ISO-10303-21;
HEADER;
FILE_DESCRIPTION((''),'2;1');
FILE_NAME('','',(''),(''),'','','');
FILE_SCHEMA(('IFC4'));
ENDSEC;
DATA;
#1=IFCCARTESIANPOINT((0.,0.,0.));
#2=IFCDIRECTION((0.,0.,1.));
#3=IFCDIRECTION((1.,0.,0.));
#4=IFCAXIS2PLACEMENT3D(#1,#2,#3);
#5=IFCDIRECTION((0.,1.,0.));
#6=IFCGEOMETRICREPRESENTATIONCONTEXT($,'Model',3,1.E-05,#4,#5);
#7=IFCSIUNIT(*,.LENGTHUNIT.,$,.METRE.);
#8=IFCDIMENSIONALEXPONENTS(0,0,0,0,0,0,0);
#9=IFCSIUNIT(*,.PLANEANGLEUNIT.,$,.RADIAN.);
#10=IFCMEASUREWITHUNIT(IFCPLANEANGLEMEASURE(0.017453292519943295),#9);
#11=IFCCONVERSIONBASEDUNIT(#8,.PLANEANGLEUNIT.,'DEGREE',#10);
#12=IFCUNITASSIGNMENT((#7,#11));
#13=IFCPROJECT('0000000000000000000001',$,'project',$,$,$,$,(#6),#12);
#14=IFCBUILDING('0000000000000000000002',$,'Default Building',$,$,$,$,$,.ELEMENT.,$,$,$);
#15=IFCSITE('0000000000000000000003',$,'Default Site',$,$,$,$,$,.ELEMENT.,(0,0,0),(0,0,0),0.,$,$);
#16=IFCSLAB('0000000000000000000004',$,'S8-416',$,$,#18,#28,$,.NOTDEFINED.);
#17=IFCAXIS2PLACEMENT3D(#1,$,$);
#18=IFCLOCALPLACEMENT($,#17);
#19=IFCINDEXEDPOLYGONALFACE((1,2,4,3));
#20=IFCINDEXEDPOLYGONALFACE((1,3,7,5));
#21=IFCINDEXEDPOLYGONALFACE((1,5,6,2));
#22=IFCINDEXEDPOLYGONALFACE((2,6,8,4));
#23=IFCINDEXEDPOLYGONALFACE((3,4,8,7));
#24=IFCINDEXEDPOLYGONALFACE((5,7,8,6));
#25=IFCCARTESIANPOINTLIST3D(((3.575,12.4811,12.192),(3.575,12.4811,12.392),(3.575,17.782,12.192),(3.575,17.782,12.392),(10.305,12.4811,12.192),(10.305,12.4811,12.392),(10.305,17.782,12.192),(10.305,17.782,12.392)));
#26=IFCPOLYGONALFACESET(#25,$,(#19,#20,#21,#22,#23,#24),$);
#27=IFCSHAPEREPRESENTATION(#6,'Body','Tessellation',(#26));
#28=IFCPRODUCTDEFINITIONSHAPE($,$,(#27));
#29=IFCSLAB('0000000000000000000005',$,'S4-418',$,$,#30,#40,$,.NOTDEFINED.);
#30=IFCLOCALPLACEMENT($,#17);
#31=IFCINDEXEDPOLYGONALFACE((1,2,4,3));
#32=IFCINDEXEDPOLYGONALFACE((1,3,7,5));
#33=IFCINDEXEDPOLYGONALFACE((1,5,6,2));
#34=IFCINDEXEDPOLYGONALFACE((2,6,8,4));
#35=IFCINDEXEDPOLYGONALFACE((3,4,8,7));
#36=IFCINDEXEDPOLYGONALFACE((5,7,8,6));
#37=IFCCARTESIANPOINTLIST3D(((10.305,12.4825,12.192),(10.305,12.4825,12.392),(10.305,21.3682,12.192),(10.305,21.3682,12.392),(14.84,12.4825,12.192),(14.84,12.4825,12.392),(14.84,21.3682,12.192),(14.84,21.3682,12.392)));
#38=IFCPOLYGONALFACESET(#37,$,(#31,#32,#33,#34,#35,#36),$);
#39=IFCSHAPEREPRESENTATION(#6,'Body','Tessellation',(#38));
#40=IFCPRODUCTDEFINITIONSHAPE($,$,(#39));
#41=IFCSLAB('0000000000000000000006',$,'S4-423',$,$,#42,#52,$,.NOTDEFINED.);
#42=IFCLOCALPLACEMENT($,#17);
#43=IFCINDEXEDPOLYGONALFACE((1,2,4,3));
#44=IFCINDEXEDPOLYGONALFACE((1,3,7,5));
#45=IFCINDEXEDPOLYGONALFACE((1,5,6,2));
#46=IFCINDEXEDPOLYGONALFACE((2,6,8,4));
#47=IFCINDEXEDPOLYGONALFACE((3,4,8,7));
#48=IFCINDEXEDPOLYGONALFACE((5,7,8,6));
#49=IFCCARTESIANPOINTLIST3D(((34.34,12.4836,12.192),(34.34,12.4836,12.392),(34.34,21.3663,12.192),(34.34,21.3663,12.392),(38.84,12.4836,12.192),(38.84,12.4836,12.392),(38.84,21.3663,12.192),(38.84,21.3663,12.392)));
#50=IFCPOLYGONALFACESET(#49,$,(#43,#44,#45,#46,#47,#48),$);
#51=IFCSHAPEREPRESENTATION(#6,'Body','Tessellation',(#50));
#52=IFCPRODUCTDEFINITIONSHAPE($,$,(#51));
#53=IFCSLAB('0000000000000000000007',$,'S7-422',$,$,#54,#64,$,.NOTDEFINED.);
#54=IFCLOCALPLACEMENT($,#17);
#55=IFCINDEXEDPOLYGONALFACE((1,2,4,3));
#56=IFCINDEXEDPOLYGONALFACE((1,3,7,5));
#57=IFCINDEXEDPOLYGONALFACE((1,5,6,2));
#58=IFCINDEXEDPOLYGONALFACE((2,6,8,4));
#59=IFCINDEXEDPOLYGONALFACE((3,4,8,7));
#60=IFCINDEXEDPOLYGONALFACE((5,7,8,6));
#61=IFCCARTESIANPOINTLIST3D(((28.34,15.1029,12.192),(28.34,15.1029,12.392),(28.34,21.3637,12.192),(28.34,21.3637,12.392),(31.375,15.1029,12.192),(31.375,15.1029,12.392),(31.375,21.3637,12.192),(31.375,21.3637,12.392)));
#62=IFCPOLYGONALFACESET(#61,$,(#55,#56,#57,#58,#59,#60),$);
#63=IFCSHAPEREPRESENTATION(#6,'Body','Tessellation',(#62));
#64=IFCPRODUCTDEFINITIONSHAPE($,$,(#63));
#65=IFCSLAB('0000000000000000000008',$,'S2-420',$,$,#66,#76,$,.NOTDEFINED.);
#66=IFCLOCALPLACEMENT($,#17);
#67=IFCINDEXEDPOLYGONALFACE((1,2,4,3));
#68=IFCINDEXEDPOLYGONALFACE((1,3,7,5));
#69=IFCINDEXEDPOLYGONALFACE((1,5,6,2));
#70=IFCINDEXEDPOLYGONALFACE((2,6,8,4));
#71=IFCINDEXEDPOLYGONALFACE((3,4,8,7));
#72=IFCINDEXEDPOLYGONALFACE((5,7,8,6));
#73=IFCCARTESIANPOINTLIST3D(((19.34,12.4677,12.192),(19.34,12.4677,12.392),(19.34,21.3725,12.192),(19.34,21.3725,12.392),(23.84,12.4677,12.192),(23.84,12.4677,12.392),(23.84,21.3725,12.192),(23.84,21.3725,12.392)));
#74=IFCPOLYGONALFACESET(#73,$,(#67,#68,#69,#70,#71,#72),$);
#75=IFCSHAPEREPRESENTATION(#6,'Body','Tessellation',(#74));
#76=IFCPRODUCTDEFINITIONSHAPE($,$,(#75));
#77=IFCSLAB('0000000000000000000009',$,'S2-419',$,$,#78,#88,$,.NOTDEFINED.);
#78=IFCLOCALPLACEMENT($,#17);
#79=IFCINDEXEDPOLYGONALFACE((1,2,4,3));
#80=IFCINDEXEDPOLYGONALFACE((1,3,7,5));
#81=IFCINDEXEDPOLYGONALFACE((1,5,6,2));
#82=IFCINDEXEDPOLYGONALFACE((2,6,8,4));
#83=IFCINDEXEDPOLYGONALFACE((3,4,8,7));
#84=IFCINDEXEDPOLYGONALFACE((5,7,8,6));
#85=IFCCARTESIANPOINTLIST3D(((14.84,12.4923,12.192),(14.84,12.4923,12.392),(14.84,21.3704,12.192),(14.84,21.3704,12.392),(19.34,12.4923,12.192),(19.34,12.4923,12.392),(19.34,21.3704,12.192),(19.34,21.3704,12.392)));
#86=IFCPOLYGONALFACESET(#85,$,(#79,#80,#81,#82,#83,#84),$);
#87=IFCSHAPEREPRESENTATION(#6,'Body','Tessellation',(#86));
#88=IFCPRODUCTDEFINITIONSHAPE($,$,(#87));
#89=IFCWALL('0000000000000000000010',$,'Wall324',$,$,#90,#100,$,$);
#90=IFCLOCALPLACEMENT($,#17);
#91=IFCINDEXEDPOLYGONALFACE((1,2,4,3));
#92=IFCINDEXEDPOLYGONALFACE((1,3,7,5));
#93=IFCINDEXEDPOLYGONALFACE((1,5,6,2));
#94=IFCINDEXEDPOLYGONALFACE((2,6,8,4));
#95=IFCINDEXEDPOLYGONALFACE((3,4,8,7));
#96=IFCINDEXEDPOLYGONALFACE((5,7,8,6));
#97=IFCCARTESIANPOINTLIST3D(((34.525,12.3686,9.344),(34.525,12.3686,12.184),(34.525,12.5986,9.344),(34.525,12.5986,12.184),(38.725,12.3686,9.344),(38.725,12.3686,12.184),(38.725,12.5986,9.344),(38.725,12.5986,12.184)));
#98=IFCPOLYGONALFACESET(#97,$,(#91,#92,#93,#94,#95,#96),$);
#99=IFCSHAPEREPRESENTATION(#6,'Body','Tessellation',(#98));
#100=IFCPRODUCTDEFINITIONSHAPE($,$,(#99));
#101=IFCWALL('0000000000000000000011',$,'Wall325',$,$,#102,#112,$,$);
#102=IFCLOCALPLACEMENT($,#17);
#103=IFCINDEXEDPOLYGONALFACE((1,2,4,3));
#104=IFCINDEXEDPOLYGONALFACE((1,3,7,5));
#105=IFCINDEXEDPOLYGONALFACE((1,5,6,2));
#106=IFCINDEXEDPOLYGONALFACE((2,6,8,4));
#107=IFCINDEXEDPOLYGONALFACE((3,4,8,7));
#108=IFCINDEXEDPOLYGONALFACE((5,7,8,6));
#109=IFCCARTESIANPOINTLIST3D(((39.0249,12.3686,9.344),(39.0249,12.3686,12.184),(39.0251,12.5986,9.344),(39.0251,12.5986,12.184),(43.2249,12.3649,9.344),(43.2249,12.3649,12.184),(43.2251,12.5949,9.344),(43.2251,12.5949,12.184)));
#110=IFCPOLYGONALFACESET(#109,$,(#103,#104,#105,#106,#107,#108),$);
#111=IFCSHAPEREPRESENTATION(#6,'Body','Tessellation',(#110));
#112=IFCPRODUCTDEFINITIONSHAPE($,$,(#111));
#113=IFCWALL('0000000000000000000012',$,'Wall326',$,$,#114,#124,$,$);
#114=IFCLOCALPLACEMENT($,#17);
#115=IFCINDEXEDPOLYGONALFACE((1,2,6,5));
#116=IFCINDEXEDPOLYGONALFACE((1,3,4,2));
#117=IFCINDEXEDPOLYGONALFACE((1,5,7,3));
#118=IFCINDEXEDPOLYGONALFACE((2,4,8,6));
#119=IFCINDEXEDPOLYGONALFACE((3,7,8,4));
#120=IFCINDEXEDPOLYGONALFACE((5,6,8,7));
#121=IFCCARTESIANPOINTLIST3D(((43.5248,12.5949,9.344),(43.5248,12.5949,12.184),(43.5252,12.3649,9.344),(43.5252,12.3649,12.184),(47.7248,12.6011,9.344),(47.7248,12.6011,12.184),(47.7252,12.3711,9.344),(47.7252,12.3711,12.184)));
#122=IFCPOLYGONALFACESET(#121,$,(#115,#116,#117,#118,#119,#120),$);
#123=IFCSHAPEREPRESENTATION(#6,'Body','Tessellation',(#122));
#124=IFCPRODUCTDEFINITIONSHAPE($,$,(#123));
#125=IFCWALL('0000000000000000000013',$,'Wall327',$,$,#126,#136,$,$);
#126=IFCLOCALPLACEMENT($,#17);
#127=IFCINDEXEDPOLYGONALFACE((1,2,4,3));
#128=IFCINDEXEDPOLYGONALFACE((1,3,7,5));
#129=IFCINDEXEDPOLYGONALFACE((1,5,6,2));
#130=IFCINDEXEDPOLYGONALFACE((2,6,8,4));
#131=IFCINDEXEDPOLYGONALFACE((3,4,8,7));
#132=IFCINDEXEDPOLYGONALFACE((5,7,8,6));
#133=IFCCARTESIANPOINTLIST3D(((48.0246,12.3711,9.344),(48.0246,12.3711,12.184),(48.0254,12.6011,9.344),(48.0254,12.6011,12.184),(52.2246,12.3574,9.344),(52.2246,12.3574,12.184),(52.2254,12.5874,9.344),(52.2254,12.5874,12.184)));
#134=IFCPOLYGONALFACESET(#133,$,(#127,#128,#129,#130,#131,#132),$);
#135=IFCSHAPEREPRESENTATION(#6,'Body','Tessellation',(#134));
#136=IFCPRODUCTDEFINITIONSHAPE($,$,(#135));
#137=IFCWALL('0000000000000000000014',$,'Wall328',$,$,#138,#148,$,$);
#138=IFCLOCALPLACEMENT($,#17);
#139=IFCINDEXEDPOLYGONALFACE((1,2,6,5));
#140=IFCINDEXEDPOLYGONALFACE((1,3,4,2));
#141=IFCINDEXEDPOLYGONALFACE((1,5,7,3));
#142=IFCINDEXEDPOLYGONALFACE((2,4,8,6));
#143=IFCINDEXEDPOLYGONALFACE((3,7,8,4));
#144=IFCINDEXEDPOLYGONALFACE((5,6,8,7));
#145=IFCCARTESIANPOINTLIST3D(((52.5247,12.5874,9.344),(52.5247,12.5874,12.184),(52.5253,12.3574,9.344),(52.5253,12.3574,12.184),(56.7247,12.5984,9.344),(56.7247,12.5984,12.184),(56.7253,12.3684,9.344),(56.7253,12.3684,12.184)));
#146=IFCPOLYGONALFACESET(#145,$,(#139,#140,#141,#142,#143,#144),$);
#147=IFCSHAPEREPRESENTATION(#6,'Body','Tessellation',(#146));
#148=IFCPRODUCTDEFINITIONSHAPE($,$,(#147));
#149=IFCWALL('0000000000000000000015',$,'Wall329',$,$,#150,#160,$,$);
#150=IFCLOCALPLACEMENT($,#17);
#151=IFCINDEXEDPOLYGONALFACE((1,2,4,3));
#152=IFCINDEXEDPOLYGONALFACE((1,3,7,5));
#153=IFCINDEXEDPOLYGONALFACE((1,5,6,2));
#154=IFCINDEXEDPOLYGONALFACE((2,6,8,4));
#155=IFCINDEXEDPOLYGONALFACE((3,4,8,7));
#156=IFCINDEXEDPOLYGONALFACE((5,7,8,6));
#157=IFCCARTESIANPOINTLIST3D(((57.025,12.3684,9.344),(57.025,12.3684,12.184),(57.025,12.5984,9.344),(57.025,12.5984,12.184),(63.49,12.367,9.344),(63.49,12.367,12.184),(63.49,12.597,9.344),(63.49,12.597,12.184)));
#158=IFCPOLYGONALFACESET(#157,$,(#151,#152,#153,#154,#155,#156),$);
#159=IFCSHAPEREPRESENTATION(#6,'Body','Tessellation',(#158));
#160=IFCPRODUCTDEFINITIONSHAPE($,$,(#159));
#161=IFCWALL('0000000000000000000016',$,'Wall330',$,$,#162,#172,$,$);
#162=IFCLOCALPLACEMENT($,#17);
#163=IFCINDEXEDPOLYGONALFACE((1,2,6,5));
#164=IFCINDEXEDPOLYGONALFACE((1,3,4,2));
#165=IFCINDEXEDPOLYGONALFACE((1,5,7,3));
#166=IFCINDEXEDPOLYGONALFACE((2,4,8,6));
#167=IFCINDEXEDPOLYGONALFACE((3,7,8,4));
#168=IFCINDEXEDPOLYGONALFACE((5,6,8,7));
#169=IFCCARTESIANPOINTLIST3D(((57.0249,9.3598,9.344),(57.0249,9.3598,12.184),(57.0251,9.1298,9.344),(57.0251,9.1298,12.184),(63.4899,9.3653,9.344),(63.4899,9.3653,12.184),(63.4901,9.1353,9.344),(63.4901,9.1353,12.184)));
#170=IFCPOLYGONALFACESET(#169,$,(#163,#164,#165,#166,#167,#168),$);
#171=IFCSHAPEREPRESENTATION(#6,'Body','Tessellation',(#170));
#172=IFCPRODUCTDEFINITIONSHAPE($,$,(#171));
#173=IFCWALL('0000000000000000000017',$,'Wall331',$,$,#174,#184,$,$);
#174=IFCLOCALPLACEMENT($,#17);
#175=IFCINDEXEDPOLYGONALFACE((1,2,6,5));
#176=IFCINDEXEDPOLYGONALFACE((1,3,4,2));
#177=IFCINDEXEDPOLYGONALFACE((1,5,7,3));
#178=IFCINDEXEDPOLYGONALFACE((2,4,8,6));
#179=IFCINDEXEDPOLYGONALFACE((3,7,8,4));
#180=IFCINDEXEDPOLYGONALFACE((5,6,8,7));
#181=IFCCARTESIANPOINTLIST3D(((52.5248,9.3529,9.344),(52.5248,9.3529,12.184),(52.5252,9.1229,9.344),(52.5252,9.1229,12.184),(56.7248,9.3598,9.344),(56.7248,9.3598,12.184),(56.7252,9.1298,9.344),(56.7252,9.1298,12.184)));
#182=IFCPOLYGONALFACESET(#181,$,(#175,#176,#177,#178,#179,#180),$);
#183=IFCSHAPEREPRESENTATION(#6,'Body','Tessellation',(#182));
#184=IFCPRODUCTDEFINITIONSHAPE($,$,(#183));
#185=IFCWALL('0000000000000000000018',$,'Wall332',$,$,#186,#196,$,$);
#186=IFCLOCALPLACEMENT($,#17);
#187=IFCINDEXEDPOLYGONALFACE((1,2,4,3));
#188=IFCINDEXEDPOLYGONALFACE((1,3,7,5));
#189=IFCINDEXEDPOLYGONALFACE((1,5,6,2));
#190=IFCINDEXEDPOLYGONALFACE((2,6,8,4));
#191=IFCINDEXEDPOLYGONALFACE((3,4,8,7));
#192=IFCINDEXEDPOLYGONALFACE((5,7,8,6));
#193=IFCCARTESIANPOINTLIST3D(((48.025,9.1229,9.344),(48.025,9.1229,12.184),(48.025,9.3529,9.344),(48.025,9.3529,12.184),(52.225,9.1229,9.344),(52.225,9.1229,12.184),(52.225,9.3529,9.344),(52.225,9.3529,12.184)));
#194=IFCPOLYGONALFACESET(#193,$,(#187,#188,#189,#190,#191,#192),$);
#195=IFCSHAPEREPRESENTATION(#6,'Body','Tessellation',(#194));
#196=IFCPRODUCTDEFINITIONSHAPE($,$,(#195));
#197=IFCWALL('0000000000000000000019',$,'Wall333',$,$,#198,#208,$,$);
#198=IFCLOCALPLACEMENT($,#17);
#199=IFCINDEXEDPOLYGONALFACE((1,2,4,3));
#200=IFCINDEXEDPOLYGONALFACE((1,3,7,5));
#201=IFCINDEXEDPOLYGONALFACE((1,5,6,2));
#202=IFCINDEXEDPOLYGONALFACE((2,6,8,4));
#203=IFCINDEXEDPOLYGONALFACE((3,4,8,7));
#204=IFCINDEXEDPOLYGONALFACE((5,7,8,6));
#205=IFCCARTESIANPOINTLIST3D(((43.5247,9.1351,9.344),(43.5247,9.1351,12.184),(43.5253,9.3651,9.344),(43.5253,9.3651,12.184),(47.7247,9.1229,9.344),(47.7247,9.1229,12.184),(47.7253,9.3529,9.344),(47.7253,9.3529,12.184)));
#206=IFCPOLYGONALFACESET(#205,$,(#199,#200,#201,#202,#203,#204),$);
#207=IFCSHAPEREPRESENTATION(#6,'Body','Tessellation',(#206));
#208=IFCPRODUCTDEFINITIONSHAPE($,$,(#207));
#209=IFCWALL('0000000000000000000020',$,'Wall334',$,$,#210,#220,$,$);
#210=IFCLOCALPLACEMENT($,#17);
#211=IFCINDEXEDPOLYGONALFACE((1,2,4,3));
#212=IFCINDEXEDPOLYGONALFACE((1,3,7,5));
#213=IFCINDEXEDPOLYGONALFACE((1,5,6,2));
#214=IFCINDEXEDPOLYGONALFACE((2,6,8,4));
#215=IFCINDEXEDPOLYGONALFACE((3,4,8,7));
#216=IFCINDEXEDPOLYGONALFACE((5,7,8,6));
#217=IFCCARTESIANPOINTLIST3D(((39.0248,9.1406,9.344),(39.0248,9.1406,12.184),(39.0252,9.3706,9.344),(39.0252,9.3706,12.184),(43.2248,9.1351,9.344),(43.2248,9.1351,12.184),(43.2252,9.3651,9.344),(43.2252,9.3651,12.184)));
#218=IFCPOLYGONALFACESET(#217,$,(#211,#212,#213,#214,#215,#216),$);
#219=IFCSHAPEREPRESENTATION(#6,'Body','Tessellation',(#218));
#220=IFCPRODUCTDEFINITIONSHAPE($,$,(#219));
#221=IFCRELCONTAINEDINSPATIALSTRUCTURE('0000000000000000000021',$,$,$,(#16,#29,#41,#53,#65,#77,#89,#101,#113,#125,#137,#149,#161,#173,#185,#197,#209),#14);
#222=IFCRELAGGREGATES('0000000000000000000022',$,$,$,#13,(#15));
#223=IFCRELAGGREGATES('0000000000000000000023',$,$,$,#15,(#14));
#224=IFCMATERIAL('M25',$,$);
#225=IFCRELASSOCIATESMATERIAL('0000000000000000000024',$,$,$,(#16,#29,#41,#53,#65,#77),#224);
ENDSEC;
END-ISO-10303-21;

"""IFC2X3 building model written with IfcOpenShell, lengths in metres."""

from ifc_helpers import new_model, entity, si_unit, converted_unit, direction, frame, frame_2d, origin_with_axes, place, context, project, spatial, rectangle, extrude, material, element, save


model = new_model("IFC2X3")

# Units and contexts
model_context = context("Model", 3, precision=1e-05, world=origin_with_axes(), true_north=direction((0.0, 1.0, 0.0)))
ifc_project = project(units=[si_unit("LENGTHUNIT", "METRE"), converted_unit("PLANEANGLEUNIT", "DEGREE", entity("IfcPlaneAngleMeasure", 0.017453292519943295), si_unit("PLANEANGLEUNIT", "RADIAN"), dimensions=[0, 0, 0, 0, 0, 0, 0])], contexts=[model_context])

# Site, building
site = spatial("IfcSite", under=ifc_project, Name="Default Site", CompositionType="ELEMENT", RefLatitude=(0, 0, 0), RefLongitude=(0, 0, 0), RefElevation=0.0)
building = spatial("IfcBuilding", under=site, Name="Default Building", CompositionType="ELEMENT")

# Slabs
ifc_material = material(Name="M25")
placement = place(None, origin_with_axes())
element("IfcSlab", 1, at=placement, inside=building, material=ifc_material, Name="S8-416", PredefinedType="NOTDEFINED", context=model_context, shape_type="SweptSolid", body=[
    extrude(rectangle(XDim=6.73, YDim=5.3009, at=frame_2d((0.0, 0.0), x_axis=(1.0, 0.0, 0.0))), frame((6.94, 15.1315, 12.192), z_axis=(0.0, 0.0, 1.0), x_axis=(1.0, 0.0, 0.0)), (0.0, 0.0, 1.0), 0.2),
])
element("IfcSlab", 2, at=placement, inside=building, material=ifc_material, Name="S4-418", PredefinedType="NOTDEFINED", context=model_context, shape_type="SweptSolid", body=[
    extrude(rectangle(XDim=4.535, YDim=8.8857, at=frame_2d((0.0, 0.0), x_axis=(1.0, 0.0, 0.0))), frame((12.5725, 16.9253, 12.192), z_axis=(0.0, 0.0, 1.0), x_axis=(1.0, 0.0, 0.0)), (0.0, 0.0, 1.0), 0.2),
])
element("IfcSlab", 3, at=placement, inside=building, material=ifc_material, Name="S4-423", PredefinedType="NOTDEFINED", context=model_context, shape_type="SweptSolid", body=[
    extrude(rectangle(XDim=4.5, YDim=8.8827, at=frame_2d((0.0, 0.0), x_axis=(1.0, 0.0, 0.0))), frame((36.59, 16.925, 12.192), z_axis=(0.0, 0.0, 1.0), x_axis=(1.0, 0.0, 0.0)), (0.0, 0.0, 1.0), 0.2),
])
element("IfcSlab", 4, at=placement, inside=building, material=ifc_material, Name="S7-422", PredefinedType="NOTDEFINED", context=model_context, shape_type="SweptSolid", body=[
    extrude(rectangle(XDim=3.035, YDim=6.2608, at=frame_2d((0.0, 0.0), x_axis=(1.0, 0.0, 0.0))), frame((29.8575, 18.2333, 12.192), z_axis=(0.0, 0.0, 1.0), x_axis=(1.0, 0.0, 0.0)), (0.0, 0.0, 1.0), 0.2),
])
element("IfcSlab", 5, at=placement, inside=building, material=ifc_material, Name="S2-420", PredefinedType="NOTDEFINED", context=model_context, shape_type="SweptSolid", body=[
    extrude(rectangle(XDim=4.5, YDim=8.9048, at=frame_2d((0.0, 0.0), x_axis=(1.0, 0.0, 0.0))), frame((21.59, 16.9201, 12.192), z_axis=(0.0, 0.0, 1.0), x_axis=(1.0, 0.0, 0.0)), (0.0, 0.0, 1.0), 0.2),
])
element("IfcSlab", 6, at=placement, inside=building, material=ifc_material, Name="S2-419", PredefinedType="NOTDEFINED", context=model_context, shape_type="SweptSolid", body=[
    extrude(rectangle(XDim=4.5, YDim=8.8781, at=frame_2d((0.0, 0.0), x_axis=(1.0, 0.0, 0.0))), frame((17.09, 16.9313, 12.192), z_axis=(0.0, 0.0, 1.0), x_axis=(1.0, 0.0, 0.0)), (0.0, 0.0, 1.0), 0.2),
])

# Walls
element("IfcWall", 7, at=placement, inside=building, Name="Wall324", context=model_context, shape_type="SweptSolid", body=[
    extrude(rectangle(XDim=4.2, YDim=0.23, at=frame_2d((0.0, 0.0), x_axis=(-1.0, 0.000008, 0.0))), frame((36.625, 12.4836, 9.344), z_axis=(0.0, 0.0, 1.0), x_axis=(1.0, 0.0, 0.0)), (0.0, 0.0, 1.0), 2.84),
])
element("IfcWall", 8, at=placement, inside=building, Name="Wall325", context=model_context, shape_type="SweptSolid", body=[
    extrude(rectangle(XDim=4.2, YDim=0.23, at=frame_2d((0.0, 0.0), x_axis=(1.0, -0.000885, 0.0))), frame((41.125, 12.4817, 9.344), z_axis=(0.0, 0.0, 1.0), x_axis=(1.0, 0.0, 0.0)), (0.0, 0.0, 1.0), 2.84),
])
element("IfcWall", 9, at=placement, inside=building, Name="Wall326", context=model_context, shape_type="SweptSolid", body=[
    extrude(rectangle(XDim=4.2, YDim=0.23, at=frame_2d((0.0, 0.0), x_axis=(-0.999999, -0.001472, 0.0))), frame((45.625, 12.483, 9.344), z_axis=(0.0, 0.0, 1.0), x_axis=(1.0, 0.0, 0.0)), (0.0, 0.0, 1.0), 2.84),
])
element("IfcWall", 10, at=placement, inside=building, Name="Wall327", context=model_context, shape_type="SweptSolid", body=[
    extrude(rectangle(XDim=4.2, YDim=0.23, at=frame_2d((0.0, 0.0), x_axis=(0.999995, -0.003262, 0.0))), frame((50.125, 12.4792, 9.344), z_axis=(0.0, 0.0, 1.0), x_axis=(1.0, 0.0, 0.0)), (0.0, 0.0, 1.0), 2.84),
])
element("IfcWall", 11, at=placement, inside=building, Name="Wall328", context=model_context, shape_type="SweptSolid", body=[
    extrude(rectangle(XDim=4.2, YDim=0.23, at=frame_2d((0.0, 0.0), x_axis=(-0.999997, -0.002631, 0.0))), frame((54.625, 12.4779, 9.344), z_axis=(0.0, 0.0, 1.0), x_axis=(1.0, 0.0, 0.0)), (0.0, 0.0, 1.0), 2.84),
])
element("IfcWall", 12, at=placement, inside=building, Name="Wall329", context=model_context, shape_type="SweptSolid", body=[
    extrude(rectangle(XDim=6.465, YDim=0.23, at=frame_2d((0.0, 0.0), x_axis=(1.0, -0.000226, 0.0))), frame((60.2575, 12.4827, 9.344), z_axis=(0.0, 0.0, 1.0), x_axis=(1.0, 0.0, 0.0)), (0.0, 0.0, 1.0), 2.84),
])
element("IfcWall", 13, at=placement, inside=building, Name="Wall330", context=model_context, shape_type="SweptSolid", body=[
    extrude(rectangle(XDim=6.465, YDim=0.23, at=frame_2d((0.0, 0.0), x_axis=(-1.0, -0.000853, 0.0))), frame((60.2575, 9.2476, 9.344), z_axis=(0.0, 0.0, 1.0), x_axis=(1.0, 0.0, 0.0)), (0.0, 0.0, 1.0), 2.84),
])
element("IfcWall", 14, at=placement, inside=building, Name="Wall331", context=model_context, shape_type="SweptSolid", body=[
    extrude(rectangle(XDim=4.2, YDim=0.23, at=frame_2d((0.0, 0.0), x_axis=(0.999999, 0.001646, 0.0))), frame((54.625, 9.2414, 9.344), z_axis=(0.0, 0.0, 1.0), x_axis=(1.0, 0.0, 0.0)), (0.0, 0.0, 1.0), 2.84),
])
element("IfcWall", 15, at=placement, inside=building, Name="Wall332", context=model_context, shape_type="SweptSolid", body=[
    extrude(rectangle(XDim=4.2, YDim=0.23, at=frame_2d((0.0, 0.0), x_axis=(-1.0, 0.0, 0.0))), frame((50.125, 9.2379, 9.344), z_axis=(0.0, 0.0, 1.0), x_axis=(1.0, 0.0, 0.0)), (0.0, 0.0, 1.0), 2.84),
])
element("IfcWall", 16, at=placement, inside=building, Name="Wall333", context=model_context, shape_type="SweptSolid", body=[
    extrude(rectangle(XDim=4.2, YDim=0.23, at=frame_2d((0.0, 0.0), x_axis=(0.999996, -0.002895, 0.0))), frame((45.625, 9.244, 9.344), z_axis=(0.0, 0.0, 1.0), x_axis=(1.0, 0.0, 0.0)), (0.0, 0.0, 1.0), 2.84),
])
element("IfcWall", 17, at=placement, inside=building, Name="Wall334", context=model_context, shape_type="SweptSolid", body=[
    extrude(rectangle(XDim=4.2, YDim=0.23, at=frame_2d((0.0, 0.0), x_axis=(-0.999999, 0.001314, 0.0))), frame((41.125, 9.2528, 9.344), z_axis=(0.0, 0.0, 1.0), x_axis=(1.0, 0.0, 0.0)), (0.0, 0.0, 1.0), 2.84),
])

save(model, "model.ifc")
